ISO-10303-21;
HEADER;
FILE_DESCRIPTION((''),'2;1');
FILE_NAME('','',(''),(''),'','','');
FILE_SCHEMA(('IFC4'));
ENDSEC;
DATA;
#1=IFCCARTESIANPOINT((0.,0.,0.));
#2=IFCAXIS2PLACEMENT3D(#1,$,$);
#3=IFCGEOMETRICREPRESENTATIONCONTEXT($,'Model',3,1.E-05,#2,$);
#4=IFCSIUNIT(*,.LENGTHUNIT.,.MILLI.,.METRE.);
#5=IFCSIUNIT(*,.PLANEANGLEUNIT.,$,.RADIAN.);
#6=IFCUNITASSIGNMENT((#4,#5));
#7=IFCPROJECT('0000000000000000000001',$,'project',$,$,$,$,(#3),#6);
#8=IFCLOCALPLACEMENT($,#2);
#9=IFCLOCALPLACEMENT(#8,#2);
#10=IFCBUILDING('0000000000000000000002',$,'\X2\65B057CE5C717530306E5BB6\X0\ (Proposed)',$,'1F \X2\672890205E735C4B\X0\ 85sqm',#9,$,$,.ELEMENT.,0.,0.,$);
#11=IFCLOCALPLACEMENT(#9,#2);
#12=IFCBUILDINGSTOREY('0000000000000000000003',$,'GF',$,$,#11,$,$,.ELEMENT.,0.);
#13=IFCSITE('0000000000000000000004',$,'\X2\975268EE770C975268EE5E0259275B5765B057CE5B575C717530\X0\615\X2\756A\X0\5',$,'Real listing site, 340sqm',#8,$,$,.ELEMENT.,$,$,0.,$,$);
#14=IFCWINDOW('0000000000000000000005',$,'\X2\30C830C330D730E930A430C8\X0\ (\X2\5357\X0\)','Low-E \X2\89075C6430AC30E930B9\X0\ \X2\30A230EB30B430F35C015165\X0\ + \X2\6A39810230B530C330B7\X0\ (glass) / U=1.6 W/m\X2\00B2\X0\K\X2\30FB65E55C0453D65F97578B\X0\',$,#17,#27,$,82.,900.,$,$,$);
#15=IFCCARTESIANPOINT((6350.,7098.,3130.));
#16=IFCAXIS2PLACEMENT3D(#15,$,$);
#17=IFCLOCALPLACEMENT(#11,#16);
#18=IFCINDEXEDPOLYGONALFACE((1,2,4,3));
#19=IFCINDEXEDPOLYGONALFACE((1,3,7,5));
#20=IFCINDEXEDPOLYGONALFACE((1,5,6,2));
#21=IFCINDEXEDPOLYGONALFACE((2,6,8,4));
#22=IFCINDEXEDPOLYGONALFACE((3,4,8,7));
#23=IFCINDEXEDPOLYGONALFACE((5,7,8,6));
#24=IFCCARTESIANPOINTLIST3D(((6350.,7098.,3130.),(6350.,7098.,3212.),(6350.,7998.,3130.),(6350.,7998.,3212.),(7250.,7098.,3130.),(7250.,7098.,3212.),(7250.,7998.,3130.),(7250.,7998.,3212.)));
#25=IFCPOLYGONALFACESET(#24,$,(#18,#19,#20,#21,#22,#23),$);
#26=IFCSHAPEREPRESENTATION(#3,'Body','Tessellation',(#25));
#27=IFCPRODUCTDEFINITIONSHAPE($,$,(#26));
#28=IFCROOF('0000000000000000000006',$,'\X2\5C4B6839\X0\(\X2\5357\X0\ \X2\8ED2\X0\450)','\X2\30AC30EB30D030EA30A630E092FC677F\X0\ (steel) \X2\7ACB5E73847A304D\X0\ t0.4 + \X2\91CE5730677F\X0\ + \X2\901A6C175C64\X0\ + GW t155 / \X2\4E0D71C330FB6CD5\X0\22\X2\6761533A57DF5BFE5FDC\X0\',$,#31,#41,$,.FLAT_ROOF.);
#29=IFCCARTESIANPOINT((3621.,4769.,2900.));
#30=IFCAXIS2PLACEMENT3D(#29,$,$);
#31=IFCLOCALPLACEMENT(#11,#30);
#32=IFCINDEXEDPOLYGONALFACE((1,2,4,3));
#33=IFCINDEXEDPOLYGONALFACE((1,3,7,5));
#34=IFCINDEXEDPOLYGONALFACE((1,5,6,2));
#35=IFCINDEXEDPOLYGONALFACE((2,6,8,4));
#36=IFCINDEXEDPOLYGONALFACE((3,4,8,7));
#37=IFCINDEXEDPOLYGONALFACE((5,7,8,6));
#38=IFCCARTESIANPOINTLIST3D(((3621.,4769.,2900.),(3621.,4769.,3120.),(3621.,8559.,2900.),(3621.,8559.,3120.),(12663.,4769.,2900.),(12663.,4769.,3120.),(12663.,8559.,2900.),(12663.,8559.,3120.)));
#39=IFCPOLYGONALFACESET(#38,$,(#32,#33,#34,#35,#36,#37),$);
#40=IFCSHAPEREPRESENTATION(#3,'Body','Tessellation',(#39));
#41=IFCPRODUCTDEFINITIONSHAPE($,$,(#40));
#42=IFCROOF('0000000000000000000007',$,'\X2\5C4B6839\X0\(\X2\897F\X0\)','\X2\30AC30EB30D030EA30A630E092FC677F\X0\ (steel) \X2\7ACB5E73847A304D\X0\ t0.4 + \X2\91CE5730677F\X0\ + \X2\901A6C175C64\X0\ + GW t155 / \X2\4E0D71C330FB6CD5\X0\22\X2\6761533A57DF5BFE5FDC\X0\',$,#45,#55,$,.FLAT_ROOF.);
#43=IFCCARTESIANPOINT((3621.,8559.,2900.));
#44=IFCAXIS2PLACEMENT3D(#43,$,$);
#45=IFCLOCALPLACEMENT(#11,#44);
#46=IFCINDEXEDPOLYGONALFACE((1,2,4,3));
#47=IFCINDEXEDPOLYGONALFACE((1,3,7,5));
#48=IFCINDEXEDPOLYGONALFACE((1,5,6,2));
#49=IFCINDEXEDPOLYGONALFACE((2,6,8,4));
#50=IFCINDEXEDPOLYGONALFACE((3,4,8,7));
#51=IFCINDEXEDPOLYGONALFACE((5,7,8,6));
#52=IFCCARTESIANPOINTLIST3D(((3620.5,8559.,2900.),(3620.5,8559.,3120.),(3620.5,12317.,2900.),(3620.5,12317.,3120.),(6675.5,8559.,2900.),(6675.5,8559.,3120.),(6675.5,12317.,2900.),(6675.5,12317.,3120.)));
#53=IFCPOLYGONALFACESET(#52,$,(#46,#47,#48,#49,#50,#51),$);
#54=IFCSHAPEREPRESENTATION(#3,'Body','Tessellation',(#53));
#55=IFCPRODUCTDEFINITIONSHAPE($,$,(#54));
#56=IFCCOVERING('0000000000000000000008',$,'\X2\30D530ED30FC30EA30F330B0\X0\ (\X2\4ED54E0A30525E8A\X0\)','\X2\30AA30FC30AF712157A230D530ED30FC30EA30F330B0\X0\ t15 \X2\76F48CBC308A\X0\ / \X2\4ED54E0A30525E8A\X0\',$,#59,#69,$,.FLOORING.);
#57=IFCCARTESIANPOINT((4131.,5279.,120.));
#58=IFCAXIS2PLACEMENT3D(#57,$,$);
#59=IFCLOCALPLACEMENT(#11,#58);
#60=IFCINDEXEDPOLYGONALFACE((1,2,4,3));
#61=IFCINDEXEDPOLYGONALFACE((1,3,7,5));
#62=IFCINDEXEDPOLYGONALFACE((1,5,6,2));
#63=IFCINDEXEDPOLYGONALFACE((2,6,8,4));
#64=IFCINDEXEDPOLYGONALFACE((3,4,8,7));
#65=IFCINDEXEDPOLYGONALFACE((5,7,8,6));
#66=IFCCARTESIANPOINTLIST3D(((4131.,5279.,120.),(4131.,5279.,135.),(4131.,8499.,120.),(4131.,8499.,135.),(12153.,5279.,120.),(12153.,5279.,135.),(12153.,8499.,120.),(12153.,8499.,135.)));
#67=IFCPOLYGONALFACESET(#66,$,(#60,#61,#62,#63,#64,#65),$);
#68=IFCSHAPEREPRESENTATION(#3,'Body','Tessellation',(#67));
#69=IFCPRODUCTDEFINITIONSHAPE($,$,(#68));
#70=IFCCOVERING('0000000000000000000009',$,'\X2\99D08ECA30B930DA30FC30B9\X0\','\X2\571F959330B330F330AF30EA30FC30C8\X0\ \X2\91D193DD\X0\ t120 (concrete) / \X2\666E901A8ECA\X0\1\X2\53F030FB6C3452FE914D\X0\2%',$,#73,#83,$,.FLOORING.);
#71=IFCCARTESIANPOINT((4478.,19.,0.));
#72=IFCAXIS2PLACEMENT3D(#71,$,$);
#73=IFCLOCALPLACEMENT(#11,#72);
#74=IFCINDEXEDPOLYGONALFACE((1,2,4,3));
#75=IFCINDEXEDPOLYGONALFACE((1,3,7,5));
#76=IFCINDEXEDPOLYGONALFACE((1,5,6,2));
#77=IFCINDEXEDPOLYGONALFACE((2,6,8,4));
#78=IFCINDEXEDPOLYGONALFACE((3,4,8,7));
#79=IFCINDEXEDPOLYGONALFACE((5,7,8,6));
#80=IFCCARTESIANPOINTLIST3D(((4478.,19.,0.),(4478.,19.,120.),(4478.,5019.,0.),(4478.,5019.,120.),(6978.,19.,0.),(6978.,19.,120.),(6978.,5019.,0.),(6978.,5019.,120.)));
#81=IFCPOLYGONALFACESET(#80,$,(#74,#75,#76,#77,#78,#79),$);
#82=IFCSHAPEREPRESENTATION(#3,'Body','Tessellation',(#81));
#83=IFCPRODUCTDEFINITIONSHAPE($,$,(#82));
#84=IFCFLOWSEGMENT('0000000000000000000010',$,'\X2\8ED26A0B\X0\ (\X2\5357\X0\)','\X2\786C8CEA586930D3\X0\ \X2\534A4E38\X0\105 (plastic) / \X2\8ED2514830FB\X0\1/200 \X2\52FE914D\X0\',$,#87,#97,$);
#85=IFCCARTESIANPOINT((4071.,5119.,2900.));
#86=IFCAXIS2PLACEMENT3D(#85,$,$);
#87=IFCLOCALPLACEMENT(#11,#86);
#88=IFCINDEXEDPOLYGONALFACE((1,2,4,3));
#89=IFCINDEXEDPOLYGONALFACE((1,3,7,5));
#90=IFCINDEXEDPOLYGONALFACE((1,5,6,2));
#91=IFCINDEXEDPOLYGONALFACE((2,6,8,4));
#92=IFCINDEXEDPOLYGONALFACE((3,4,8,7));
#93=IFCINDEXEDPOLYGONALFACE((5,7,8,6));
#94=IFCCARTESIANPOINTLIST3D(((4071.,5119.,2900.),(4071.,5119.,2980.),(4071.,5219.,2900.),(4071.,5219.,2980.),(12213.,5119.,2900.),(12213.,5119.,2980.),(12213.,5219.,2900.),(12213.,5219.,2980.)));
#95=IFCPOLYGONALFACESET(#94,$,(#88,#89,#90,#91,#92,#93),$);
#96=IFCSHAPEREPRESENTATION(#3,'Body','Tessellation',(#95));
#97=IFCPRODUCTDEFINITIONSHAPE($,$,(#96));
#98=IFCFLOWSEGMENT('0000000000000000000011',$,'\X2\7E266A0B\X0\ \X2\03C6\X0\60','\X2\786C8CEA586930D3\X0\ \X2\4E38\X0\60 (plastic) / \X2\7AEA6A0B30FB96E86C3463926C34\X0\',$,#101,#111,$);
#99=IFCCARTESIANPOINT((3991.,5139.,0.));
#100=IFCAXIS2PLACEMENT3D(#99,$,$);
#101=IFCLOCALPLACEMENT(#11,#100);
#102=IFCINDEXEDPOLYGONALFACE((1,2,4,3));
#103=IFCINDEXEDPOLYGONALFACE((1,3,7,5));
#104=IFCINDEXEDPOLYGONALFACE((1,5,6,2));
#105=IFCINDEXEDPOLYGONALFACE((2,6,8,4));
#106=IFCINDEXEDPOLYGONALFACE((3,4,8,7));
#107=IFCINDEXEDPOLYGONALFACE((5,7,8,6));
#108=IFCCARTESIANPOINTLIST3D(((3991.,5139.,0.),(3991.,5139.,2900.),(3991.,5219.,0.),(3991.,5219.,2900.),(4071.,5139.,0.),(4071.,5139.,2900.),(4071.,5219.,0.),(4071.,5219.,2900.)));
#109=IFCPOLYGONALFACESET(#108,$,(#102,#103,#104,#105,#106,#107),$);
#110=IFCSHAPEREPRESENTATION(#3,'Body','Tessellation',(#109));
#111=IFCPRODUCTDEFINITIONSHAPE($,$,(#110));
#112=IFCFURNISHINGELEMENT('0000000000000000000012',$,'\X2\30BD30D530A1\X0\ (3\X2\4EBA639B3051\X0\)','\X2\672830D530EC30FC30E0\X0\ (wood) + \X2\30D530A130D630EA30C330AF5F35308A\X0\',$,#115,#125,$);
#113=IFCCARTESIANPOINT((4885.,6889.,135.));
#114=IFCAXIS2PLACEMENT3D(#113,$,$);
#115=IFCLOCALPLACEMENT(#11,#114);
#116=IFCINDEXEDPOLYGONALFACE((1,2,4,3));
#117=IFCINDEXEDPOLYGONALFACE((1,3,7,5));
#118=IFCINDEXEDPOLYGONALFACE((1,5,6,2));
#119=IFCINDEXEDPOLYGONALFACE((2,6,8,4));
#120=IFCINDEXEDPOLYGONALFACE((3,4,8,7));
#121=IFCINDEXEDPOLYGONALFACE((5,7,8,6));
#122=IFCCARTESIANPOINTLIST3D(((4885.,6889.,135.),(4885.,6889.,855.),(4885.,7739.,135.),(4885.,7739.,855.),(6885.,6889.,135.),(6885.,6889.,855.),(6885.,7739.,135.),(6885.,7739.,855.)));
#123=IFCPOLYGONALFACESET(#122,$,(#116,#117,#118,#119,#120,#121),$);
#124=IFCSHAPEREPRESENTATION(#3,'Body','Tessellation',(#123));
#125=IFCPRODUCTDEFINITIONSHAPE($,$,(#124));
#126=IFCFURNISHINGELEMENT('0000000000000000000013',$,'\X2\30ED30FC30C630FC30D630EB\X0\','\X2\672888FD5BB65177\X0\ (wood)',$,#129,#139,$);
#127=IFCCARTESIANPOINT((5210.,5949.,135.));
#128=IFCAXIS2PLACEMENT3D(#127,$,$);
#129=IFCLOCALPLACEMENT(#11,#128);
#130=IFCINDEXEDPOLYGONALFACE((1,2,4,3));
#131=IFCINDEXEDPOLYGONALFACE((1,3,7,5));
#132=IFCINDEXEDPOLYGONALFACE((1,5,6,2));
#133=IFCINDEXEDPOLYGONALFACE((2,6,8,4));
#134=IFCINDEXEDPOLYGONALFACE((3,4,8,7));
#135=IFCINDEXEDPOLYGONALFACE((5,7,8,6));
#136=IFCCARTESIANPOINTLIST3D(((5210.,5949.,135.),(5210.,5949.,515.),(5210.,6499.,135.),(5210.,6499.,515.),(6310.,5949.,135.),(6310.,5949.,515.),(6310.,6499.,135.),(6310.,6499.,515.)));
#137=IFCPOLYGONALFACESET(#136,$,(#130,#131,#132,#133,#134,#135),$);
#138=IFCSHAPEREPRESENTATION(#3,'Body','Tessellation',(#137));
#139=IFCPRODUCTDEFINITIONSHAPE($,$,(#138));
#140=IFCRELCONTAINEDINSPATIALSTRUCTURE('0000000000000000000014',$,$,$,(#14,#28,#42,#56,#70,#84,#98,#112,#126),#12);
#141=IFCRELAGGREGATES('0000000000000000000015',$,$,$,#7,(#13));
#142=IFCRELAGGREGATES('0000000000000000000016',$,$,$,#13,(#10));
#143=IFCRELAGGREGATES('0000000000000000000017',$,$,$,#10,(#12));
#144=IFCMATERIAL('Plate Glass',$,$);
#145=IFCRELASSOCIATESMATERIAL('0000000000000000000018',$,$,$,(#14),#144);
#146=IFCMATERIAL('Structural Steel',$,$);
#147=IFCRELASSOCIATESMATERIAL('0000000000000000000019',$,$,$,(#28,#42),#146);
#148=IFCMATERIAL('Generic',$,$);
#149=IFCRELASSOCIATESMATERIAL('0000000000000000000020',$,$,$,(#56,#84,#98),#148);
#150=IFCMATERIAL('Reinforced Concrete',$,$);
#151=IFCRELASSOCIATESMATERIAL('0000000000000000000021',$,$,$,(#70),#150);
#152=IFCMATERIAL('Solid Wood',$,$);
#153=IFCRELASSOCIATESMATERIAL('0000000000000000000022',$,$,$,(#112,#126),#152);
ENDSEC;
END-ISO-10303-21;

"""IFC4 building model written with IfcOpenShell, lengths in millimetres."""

from ifc_helpers import new_model, si_unit, frame, frame_2d, origin, place, context, project, spatial, rectangle, extrude, material, element, save


model = new_model("IFC4")

# Units and contexts
model_context = context("Model", 3, precision=1e-05, world=origin())
ifc_project = project(units=[si_unit("LENGTHUNIT", "METRE", prefix="MILLI"), si_unit("PLANEANGLEUNIT", "RADIAN")], contexts=[model_context])

# Site, building, storey
site_placement = place(None, origin())
site = spatial("IfcSite", under=ifc_project, at=site_placement, Name="青森県青森市大字新城字山田615番5", ObjectType="Real listing site, 340sqm", CompositionType="ELEMENT", RefElevation=0.0)
building_placement = place(site_placement, origin())
building = spatial("IfcBuilding", under=site, at=building_placement, Name="新城山田の家 (Proposed)", ObjectType="1F 木造平屋 85sqm", CompositionType="ELEMENT", ElevationOfRefHeight=0.0, ElevationOfTerrain=0.0)
storey_placement = place(building_placement, origin())
storey = spatial("IfcBuildingStorey", under=building, at=storey_placement, Name="GF", CompositionType="ELEMENT", Elevation=0.0)

# Shared definitions
ifc_material_1 = material(Name="Solid Wood")

# Shared definitions
ifc_material_2 = material(Name="Reinforced Concrete")

# Shared definitions
ifc_material_3 = material(Name="Plate Glass")

# Window
window_1_placement = place(storey_placement, frame((6350.0, 7098.0, 3130.0)))
element("IfcWindow", 1, at=window_1_placement, inside=storey, material=ifc_material_3, Name="トップライト (南)", Description="Low-E 複層ガラス アルゴン封入 + 樹脂サッシ (glass) / U=1.6 W/m²K・日射取得型", OverallHeight=82.0, OverallWidth=900.0, context=model_context, shape_type="SweptSolid", body=[
    extrude(rectangle(XDim=900.0, YDim=900.0, at=frame_2d((450.0, 450.0))), frame((6350.0, 7098.0, 3130.0)), (0.0, 0.0, 1.0), 82.0),
])

# Roofs
ifc_material_4 = material(Name="Structural Steel")
roof_1_placement = place(storey_placement, frame((3621.0, 4769.0, 2900.0)))
element("IfcRoof", 2, at=roof_1_placement, inside=storey, material=ifc_material_4, Name="屋根(南 軒450)", Description="ガルバリウム鋼板 (steel) 立平葺き t0.4 + 野地板 + 通気層 + GW t155 / 不燃・法22条区域対応", PredefinedType="FLAT_ROOF", context=model_context, shape_type="SweptSolid", body=[
    extrude(rectangle(XDim=9042.0, YDim=3790.0, at=frame_2d((4521.0, 1895.0))), frame((3621.0, 4769.0, 2900.0)), (0.0, 0.0, 1.0), 220.0),
])
roof_2_placement = place(storey_placement, frame((3621.0, 8559.0, 2900.0)))
element("IfcRoof", 3, at=roof_2_placement, inside=storey, material=ifc_material_4, Name="屋根(西)", Description="ガルバリウム鋼板 (steel) 立平葺き t0.4 + 野地板 + 通気層 + GW t155 / 不燃・法22条区域対応", PredefinedType="FLAT_ROOF", context=model_context, shape_type="SweptSolid", body=[
    extrude(rectangle(XDim=3055.0, YDim=3758.0, at=frame_2d((1527.0, 1879.0))), frame((3621.0, 8559.0, 2900.0)), (0.0, 0.0, 1.0), 220.0),
])

# Coverings
ifc_material_5 = material(Name="Generic")
covering_1_placement = place(storey_placement, frame((4131.0, 5279.0, 120.0)))
element("IfcCovering", 4, at=covering_1_placement, inside=storey, material=ifc_material_5, Name="フローリング (仕上げ床)", Description="オーク無垢フローリング t15 直貼り / 仕上げ床", PredefinedType="FLOORING", context=model_context, shape_type="SweptSolid", body=[
    extrude(rectangle(XDim=8022.0, YDim=3220.0, at=frame_2d((4011.0, 1610.0))), frame((4131.0, 5279.0, 120.0)), (0.0, 0.0, 1.0), 15.0),
])
covering_2_placement = place(storey_placement, frame((4478.0, 19.0, 0.0)))
element("IfcCovering", 5, at=covering_2_placement, inside=storey, material=ifc_material_2, Name="駐車スペース", Description="土間コンクリート 金鏝 t120 (concrete) / 普通車1台・水勾配2%", PredefinedType="FLOORING", context=model_context, shape_type="SweptSolid", body=[
    extrude(rectangle(XDim=2500.0, YDim=5000.0, at=frame_2d((1250.0, 2500.0))), frame((4478.0, 19.0, 0.0)), (0.0, 0.0, 1.0), 120.0),
])

# Flow segments
flow_segment_1_placement = place(storey_placement, frame((4071.0, 5119.0, 2900.0)))
element("IfcFlowSegment", 6, at=flow_segment_1_placement, inside=storey, material=ifc_material_5, Name="軒樋 (南)", Description="硬質塩ビ 半丸105 (plastic) / 軒先・1/200 勾配", context=model_context, shape_type="SweptSolid", body=[
    extrude(rectangle(XDim=8142.0, YDim=100.0, at=frame_2d((4071.0, 50.0))), frame((4071.0, 5119.0, 2900.0)), (0.0, 0.0, 1.0), 80.0),
])
flow_segment_2_placement = place(storey_placement, frame((3991.0, 5139.0, 0.0)))
element("IfcFlowSegment", 7, at=flow_segment_2_placement, inside=storey, material=ifc_material_5, Name="縦樋 φ60", Description="硬質塩ビ 丸60 (plastic) / 竪樋・雨水排水", context=model_context, shape_type="SweptSolid", body=[
    extrude(rectangle(XDim=80.0, YDim=80.0, at=frame_2d((40.0, 40.0))), frame((3991.0, 5139.0, 0.0)), (0.0, 0.0, 1.0), 2900.0),
])

# Furnishing elements
furnishing_1_placement = place(storey_placement, frame((4885.0, 6889.0, 135.0)))
element("IfcFurnishingElement", 8, at=furnishing_1_placement, inside=storey, material=ifc_material_1, Name="ソファ (3人掛け)", Description="木フレーム (wood) + ファブリック張り", context=model_context, shape_type="SweptSolid", body=[
    extrude(rectangle(XDim=2000.0, YDim=850.0, at=frame_2d((1000.0, 425.0))), frame((4885.0, 6889.0, 135.0)), (0.0, 0.0, 1.0), 720.0),
])
furnishing_2_placement = place(storey_placement, frame((5210.0, 5949.0, 135.0)))
element("IfcFurnishingElement", 9, at=furnishing_2_placement, inside=storey, material=ifc_material_1, Name="ローテーブル", Description="木製家具 (wood)", context=model_context, shape_type="SweptSolid", body=[
    extrude(rectangle(XDim=1100.0, YDim=550.0, at=frame_2d((550.0, 275.0))), frame((5210.0, 5949.0, 135.0)), (0.0, 0.0, 1.0), 380.0),
])

save(model, "model.ifc")
